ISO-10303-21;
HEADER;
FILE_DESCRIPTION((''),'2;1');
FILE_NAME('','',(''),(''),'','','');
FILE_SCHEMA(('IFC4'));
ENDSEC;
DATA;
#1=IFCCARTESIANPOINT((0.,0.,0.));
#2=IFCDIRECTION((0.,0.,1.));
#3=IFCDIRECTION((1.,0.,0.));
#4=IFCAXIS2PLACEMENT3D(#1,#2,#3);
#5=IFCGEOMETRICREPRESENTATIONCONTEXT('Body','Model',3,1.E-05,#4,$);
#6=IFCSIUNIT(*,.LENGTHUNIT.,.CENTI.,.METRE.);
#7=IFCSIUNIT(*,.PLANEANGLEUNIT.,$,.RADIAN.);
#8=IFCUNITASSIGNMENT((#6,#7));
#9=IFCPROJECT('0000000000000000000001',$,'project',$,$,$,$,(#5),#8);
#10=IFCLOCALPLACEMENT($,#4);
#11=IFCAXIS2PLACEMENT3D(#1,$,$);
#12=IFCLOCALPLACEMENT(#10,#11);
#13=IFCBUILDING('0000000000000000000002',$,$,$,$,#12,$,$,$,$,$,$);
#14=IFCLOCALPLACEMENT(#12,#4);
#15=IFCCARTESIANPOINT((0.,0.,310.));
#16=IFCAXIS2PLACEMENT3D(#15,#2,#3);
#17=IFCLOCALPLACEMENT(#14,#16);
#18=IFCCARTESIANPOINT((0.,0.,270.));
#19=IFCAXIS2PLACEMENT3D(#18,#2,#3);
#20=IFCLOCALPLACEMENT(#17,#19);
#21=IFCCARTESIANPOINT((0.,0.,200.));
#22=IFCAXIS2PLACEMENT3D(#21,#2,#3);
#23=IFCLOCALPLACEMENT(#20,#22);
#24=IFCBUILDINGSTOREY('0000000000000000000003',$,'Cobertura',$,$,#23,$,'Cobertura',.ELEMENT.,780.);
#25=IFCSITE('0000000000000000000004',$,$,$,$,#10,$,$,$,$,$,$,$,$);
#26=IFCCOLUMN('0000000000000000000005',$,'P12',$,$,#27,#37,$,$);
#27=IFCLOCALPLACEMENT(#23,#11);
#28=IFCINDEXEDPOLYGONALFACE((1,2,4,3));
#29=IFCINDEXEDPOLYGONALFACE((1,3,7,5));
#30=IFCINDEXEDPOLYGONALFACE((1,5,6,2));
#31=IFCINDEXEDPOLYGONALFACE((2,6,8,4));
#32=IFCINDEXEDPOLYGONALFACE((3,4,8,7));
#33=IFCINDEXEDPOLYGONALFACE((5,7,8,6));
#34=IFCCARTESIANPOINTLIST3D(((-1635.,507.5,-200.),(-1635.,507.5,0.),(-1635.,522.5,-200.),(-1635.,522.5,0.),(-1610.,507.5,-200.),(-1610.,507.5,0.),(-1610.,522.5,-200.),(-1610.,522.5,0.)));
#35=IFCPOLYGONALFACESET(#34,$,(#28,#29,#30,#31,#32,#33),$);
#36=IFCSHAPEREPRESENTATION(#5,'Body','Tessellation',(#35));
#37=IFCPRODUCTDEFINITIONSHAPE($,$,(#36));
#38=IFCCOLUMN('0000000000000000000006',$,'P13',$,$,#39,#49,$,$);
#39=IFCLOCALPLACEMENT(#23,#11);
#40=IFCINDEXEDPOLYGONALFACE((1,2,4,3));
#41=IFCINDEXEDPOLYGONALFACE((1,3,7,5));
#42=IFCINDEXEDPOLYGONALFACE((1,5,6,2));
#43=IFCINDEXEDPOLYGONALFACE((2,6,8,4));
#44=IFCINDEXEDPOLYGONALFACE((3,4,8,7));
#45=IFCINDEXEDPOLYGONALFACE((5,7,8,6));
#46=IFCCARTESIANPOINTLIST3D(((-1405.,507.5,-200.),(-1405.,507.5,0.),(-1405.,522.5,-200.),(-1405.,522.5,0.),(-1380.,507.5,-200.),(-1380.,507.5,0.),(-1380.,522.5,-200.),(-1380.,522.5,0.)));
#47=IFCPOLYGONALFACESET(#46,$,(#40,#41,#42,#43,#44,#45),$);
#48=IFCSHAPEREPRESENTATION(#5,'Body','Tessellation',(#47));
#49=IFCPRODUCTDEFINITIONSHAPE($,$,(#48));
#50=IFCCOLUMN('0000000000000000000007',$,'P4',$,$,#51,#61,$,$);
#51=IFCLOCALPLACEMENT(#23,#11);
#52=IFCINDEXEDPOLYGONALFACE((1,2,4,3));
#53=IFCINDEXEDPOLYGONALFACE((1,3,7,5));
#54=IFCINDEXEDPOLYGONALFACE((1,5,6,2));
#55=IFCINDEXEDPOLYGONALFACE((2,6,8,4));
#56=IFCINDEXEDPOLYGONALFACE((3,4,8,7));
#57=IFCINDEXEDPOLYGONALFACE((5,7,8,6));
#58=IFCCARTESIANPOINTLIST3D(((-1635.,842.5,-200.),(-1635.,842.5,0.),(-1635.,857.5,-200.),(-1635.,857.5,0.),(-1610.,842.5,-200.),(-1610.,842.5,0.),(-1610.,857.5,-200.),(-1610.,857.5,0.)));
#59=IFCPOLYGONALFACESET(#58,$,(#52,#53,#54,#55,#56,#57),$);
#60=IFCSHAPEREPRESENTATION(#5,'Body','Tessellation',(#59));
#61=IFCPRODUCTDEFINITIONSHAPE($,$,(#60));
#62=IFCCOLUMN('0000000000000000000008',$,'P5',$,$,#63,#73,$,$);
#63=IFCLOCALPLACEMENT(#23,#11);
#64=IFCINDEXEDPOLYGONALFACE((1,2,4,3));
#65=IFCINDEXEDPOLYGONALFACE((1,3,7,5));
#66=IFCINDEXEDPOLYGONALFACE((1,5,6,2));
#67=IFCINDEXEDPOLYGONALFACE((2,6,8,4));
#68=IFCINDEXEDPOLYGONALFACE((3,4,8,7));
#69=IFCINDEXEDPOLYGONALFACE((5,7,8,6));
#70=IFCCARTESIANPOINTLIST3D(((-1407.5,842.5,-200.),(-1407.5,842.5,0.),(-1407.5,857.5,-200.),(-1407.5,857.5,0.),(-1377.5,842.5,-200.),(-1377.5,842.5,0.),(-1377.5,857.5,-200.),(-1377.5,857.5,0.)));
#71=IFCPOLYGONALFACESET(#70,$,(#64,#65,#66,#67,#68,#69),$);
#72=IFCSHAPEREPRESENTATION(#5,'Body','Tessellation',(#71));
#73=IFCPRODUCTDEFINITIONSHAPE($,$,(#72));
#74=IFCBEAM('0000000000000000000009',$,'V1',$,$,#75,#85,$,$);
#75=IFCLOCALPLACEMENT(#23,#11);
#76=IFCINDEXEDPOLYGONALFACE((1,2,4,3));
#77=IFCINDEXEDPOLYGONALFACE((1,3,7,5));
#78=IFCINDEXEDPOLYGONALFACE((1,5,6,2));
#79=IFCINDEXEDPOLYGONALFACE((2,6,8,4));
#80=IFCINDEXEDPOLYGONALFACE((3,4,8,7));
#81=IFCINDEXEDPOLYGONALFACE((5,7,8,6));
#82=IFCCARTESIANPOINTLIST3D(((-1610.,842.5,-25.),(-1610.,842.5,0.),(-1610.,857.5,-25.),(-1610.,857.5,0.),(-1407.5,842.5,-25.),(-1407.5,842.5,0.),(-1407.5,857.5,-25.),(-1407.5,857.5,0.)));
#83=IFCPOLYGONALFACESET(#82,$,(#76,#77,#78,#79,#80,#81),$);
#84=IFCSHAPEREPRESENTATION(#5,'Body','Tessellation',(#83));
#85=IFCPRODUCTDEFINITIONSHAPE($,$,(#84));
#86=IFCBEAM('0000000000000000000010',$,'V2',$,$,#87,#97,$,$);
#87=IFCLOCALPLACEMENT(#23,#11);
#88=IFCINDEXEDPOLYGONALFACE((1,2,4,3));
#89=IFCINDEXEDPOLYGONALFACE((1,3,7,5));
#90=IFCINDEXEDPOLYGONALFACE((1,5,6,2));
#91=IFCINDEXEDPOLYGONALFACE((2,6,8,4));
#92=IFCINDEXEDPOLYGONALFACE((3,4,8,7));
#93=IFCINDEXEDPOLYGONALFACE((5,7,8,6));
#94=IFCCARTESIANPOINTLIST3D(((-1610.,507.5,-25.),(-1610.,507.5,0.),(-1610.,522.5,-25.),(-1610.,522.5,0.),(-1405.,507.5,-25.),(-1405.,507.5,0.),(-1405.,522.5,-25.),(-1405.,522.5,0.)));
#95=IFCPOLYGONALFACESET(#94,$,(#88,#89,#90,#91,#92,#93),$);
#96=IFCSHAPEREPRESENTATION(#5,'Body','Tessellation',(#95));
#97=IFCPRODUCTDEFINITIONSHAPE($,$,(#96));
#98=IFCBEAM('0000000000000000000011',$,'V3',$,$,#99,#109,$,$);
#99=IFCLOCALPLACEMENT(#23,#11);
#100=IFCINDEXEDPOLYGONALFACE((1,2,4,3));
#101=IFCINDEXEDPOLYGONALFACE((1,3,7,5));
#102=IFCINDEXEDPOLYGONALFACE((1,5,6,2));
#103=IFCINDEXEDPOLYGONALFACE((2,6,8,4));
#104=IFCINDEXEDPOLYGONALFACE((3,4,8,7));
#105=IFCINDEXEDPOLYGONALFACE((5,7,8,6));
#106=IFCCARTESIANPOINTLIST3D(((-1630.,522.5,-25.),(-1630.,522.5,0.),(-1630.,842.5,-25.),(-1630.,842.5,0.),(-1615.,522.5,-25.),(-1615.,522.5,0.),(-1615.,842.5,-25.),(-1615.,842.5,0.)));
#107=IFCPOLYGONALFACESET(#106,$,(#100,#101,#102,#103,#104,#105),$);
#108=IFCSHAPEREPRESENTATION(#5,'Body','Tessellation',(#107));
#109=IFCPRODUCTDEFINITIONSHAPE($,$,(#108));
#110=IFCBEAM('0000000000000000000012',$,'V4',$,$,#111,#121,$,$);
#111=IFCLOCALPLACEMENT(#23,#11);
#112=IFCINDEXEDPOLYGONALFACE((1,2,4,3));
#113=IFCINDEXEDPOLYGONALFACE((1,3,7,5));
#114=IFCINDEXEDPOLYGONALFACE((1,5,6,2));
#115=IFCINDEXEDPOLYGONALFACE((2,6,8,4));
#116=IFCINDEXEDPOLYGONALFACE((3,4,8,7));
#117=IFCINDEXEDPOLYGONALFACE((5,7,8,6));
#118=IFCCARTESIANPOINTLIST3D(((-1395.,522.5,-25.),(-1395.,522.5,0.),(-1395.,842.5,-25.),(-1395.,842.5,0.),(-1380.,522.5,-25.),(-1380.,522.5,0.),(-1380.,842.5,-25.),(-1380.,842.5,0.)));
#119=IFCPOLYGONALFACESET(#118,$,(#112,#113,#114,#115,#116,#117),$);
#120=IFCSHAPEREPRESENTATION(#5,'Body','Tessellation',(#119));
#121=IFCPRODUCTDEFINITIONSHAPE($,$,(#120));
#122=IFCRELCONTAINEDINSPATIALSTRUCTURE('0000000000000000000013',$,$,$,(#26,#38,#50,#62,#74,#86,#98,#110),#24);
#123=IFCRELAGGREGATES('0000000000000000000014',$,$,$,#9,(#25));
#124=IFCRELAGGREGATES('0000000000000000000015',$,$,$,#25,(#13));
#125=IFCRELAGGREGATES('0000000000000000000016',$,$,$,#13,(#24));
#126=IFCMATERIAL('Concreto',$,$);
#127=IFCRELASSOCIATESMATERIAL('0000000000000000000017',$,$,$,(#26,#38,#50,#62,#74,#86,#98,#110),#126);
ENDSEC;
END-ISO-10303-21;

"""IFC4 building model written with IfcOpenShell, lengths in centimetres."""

from ifc_helpers import new_model, si_unit, frame, origin, origin_with_axes, origin_2d_with_axis, place, context, project, spatial, rectangle, extrude, material, element, save


model = new_model("IFC4")

# Units and contexts
model_context = context("Model", 3, precision=1e-05, world=origin_with_axes(), identifier="Body")
ifc_project = project(units=[si_unit("LENGTHUNIT", "METRE", prefix="CENTI"), si_unit("PLANEANGLEUNIT", "RADIAN")], contexts=[model_context])

# Site, building, storey
site_placement = place(None, origin_with_axes())
site = spatial("IfcSite", under=ifc_project, at=site_placement)
building_placement = place(site_placement, origin())
building = spatial("IfcBuilding", under=site, at=building_placement)
placement_1 = place(building_placement, origin_with_axes())
placement_2 = place(placement_1, frame((0.0, 0.0, 310.0), z_axis=(0.0, 0.0, 1.0), x_axis=(1.0, 0.0, 0.0)))
placement_3 = place(placement_2, frame((0.0, 0.0, 270.0), z_axis=(0.0, 0.0, 1.0), x_axis=(1.0, 0.0, 0.0)))
storey_placement = place(placement_3, frame((0.0, 0.0, 200.0), z_axis=(0.0, 0.0, 1.0), x_axis=(1.0, 0.0, 0.0)))
storey = spatial("IfcBuildingStorey", under=building, at=storey_placement, Name="Cobertura", LongName="Cobertura", CompositionType="ELEMENT", Elevation=780.0)

# Columns
ifc_material = material(Name="Concreto")
for number, where, z_axis, x_axis, name in (
    (1, (-1622.5, 515.0, 0.0), (0.0, 0.0, 1.0), (1.0, 0.0, 0.0), "P12"),
    (2, (-1392.5, 515.0, 0.0), (0.0, 0.0, 1.0), (1.0, 0.0, 0.0), "P13"),
):
    element("IfcColumn", number, at=place(storey_placement, frame(where, z_axis=z_axis, x_axis=x_axis)), inside=storey, material=ifc_material, Name=name, context=model_context, shape_type="SolidModel", body=[
        extrude(rectangle(XDim=15.0, YDim=25.0, at=origin_2d_with_axis()), frame((0.0, 0.0, 0.0), z_axis=(0.0, 0.0, 1.0), x_axis=(0.0, 1.0, 0.0)), (0.0, 0.0, -1.0), 200.0),
    ])
column_1_placement = place(storey_placement, frame((-1622.5, 850.0, 0.0), z_axis=(0.0, 0.0, 1.0), x_axis=(1.0, 0.0, 0.0)))
element("IfcColumn", 3, at=column_1_placement, inside=storey, material=ifc_material, Name="P4", context=model_context, shape_type="SolidModel", body=[
    extrude(rectangle(XDim=15.0, YDim=25.0, at=origin_2d_with_axis()), frame((0.0, 0.0, 0.0), z_axis=(0.0, 0.0, 1.0), x_axis=(0.0, -1.0, 0.0)), (0.0, 0.0, -1.0), 200.0),
])
column_2_placement = place(storey_placement, frame((-1392.5, 850.0, 0.0), z_axis=(0.0, 0.0, 1.0), x_axis=(1.0, 0.0, 0.0)))
element("IfcColumn", 4, at=column_2_placement, inside=storey, material=ifc_material, Name="P5", context=model_context, shape_type="SolidModel", body=[
    extrude(rectangle(XDim=15.0, YDim=30.0, at=origin_2d_with_axis()), frame((0.0, 0.0, 0.0), z_axis=(0.0, 0.0, 1.0), x_axis=(0.0, 1.0, 0.0)), (0.0, 0.0, -1.0), 200.0),
])

# Beams
beam_1_placement = place(storey_placement, frame((-1508.75, 850.0, 0.0), z_axis=(0.0, 0.0, 1.0), x_axis=(1.0, 0.0, 0.0)))
element("IfcBeam", 5, at=beam_1_placement, inside=storey, material=ifc_material, Name="V1", context=model_context, shape_type="SolidModel", body=[
    extrude(rectangle(XDim=15.0, YDim=25.0, at=origin_2d_with_axis()), frame((-101.25, 0.0, -12.5), z_axis=(1.0, 0.0, 0.0), x_axis=(0.0, -1.0, 0.0)), (0.0, 0.0, 1.0), 202.5),
])
beam_2_placement = place(storey_placement, frame((-1507.5, 515.0, 0.0), z_axis=(0.0, 0.0, 1.0), x_axis=(1.0, 0.0, 0.0)))
element("IfcBeam", 6, at=beam_2_placement, inside=storey, material=ifc_material, Name="V2", context=model_context, shape_type="SolidModel", body=[
    extrude(rectangle(XDim=15.0, YDim=25.0, at=origin_2d_with_axis()), frame((-102.5, 0.0, -12.5), z_axis=(1.0, 0.0, 0.0), x_axis=(0.0, -1.0, 0.0)), (0.0, 0.0, 1.0), 205.0),
])
for number, where, z_axis, x_axis, name in (
    (7, (-1622.5, 682.5, 0.0), (0.0, 0.0, 1.0), (1.0, 0.0, 0.0), "V3"),
    (8, (-1387.5, 682.5, 0.0), (0.0, 0.0, 1.0), (1.0, 0.0, 0.0), "V4"),
):
    element("IfcBeam", number, at=place(storey_placement, frame(where, z_axis=z_axis, x_axis=x_axis)), inside=storey, material=ifc_material, Name=name, context=model_context, shape_type="SolidModel", body=[
        extrude(rectangle(XDim=15.0, YDim=25.0, at=origin_2d_with_axis()), frame((0.0, -160.0, -12.5), z_axis=(0.0, 1.0, 0.0), x_axis=(-1.0, 0.0, 0.0)), (0.0, 0.0, 1.0), 320.0),
    ])

save(model, "model.ifc")
